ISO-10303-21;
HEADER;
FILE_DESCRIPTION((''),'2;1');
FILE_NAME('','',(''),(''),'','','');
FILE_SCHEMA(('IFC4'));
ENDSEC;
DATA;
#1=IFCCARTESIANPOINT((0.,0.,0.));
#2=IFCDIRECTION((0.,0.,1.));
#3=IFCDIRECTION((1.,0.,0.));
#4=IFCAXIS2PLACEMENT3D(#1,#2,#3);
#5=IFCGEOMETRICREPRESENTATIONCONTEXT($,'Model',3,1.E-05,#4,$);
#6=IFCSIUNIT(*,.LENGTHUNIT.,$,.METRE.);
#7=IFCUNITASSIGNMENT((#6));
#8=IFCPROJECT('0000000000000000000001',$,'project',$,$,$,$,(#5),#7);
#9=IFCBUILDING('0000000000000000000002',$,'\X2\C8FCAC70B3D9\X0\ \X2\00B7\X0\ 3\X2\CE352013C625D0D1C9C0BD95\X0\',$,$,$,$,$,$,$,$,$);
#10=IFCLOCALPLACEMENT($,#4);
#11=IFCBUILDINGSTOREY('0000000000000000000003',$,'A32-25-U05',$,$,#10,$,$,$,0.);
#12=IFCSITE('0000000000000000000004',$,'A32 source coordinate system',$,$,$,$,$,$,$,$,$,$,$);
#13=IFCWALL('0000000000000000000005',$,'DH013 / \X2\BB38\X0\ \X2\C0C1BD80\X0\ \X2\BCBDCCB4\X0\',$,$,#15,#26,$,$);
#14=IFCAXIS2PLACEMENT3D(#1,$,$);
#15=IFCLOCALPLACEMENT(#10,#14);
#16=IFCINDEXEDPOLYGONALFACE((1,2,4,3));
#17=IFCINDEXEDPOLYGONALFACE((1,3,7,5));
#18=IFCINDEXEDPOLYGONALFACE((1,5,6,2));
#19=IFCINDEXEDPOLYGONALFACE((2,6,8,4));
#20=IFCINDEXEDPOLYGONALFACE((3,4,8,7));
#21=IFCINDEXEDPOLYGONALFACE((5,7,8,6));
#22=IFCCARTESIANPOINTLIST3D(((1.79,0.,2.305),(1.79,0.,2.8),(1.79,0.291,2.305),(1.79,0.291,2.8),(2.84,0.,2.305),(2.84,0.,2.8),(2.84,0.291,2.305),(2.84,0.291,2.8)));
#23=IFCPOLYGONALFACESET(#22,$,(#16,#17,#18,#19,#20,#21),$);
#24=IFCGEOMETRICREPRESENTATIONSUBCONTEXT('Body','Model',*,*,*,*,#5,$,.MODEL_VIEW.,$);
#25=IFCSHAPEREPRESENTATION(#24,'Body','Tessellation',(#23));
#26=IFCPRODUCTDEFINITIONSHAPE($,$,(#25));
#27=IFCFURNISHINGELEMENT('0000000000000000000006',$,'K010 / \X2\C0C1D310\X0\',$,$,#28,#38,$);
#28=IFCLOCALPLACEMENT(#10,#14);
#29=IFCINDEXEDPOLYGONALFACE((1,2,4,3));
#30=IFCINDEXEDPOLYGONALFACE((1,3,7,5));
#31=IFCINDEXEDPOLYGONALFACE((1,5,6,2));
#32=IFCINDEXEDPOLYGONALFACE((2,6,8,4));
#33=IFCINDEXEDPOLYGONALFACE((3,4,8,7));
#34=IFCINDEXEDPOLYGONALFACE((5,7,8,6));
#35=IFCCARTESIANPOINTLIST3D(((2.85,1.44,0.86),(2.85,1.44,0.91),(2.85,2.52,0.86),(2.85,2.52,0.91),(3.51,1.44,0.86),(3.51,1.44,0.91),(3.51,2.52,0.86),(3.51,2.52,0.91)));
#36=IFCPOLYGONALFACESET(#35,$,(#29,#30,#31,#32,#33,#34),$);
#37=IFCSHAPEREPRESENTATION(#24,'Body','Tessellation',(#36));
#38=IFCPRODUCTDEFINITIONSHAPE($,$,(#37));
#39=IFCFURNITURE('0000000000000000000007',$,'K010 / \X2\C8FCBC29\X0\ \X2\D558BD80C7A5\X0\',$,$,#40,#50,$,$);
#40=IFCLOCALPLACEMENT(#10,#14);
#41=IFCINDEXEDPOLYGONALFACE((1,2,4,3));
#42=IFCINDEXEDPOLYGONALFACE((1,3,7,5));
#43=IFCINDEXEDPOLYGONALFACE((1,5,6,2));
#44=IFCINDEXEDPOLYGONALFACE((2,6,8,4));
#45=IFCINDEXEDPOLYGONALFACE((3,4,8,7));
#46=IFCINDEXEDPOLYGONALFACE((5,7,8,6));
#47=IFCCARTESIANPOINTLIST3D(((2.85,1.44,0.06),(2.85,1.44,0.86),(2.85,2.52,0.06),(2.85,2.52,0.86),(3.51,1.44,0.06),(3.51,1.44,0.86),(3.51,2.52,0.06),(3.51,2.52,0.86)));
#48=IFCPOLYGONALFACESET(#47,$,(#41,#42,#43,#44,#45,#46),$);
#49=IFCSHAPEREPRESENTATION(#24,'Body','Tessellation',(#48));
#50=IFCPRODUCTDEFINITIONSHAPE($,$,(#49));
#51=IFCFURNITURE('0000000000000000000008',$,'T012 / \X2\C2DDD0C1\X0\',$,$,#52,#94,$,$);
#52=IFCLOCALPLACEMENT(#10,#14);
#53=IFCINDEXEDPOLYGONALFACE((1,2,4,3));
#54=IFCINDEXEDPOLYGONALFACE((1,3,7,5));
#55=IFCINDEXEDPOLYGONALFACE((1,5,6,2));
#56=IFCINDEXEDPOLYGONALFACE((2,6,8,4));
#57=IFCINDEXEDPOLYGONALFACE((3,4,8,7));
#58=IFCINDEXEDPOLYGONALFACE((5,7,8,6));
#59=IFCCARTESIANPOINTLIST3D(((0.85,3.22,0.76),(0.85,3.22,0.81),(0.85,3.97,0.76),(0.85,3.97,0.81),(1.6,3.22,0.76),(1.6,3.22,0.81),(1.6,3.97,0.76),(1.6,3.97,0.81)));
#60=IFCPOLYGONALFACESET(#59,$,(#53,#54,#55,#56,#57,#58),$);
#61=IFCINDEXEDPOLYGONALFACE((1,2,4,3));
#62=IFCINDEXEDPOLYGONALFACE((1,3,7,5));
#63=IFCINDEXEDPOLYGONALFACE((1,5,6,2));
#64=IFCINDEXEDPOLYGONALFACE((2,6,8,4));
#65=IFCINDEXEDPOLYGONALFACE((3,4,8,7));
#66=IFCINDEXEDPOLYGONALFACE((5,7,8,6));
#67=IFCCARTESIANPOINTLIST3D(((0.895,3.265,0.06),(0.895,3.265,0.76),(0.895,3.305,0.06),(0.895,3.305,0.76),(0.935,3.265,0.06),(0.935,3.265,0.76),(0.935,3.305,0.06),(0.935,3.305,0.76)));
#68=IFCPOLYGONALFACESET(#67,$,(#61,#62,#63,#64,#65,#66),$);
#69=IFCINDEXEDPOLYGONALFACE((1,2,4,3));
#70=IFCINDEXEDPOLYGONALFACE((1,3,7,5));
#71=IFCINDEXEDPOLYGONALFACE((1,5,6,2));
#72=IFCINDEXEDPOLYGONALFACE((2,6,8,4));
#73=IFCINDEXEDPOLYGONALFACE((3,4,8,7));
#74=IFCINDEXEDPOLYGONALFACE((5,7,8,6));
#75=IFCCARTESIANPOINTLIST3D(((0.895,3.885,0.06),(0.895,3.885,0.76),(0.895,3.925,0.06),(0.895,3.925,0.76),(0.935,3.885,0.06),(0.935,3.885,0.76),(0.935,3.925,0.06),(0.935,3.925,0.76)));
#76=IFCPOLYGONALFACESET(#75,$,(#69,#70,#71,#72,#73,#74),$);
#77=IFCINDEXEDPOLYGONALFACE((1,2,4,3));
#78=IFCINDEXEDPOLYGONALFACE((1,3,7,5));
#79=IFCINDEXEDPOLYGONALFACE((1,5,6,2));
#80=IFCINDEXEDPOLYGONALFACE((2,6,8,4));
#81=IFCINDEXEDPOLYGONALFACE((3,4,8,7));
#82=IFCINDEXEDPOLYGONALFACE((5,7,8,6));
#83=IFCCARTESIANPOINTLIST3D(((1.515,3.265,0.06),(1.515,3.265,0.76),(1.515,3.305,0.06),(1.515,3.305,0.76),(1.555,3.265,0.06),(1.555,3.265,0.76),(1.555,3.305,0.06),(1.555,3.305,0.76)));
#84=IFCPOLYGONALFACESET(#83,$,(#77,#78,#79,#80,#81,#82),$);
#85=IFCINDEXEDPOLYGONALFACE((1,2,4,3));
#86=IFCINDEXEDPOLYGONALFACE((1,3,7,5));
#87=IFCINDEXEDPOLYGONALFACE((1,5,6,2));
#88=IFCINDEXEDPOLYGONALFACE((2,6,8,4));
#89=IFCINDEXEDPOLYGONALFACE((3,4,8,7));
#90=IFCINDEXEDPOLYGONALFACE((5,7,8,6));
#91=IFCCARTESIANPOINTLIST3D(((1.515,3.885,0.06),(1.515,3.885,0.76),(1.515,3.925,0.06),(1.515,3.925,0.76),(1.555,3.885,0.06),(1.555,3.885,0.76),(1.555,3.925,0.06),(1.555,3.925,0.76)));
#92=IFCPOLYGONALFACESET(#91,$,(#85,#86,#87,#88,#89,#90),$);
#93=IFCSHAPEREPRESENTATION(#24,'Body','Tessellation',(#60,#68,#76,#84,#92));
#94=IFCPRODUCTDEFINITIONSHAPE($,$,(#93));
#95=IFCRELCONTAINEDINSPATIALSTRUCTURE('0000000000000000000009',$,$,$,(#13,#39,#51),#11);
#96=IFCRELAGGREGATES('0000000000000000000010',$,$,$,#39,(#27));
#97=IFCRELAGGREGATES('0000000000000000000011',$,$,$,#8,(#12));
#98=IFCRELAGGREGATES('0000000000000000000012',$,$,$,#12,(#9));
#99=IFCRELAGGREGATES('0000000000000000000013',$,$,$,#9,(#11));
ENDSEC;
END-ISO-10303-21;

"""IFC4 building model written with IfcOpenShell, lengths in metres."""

from ifc_helpers import new_model, si_unit, frame, origin_with_axes, place, context, subcontext, project, spatial, polyline, outline, extrude, element, aggregate, save


model = new_model("IFC4")

# Units and contexts
model_context = context("Model", 3, precision=1e-05, world=origin_with_axes())
body_context = subcontext(model_context, "Body", "Model", "MODEL_VIEW")
ifc_project = project(units=[si_unit("LENGTHUNIT", "METRE")], contexts=[model_context])

# Site, building, storey
site = spatial("IfcSite", under=ifc_project, Name="A32 source coordinate system")
building = spatial("IfcBuilding", under=site, Name="주거동 · 3층–옥탑지붕")
storey_placement = place(None, origin_with_axes())
storey = spatial("IfcBuildingStorey", under=building, at=storey_placement, Name="A32-25-U05", Elevation=0.0)

# Wall
wall_1_placement = place(storey_placement, origin_with_axes())
element("IfcWall", 1, at=wall_1_placement, inside=storey, Name="DH013 / 문 상부 벽체", context=body_context, shape_type="SweptSolid", body=[
    extrude(outline(polyline([(2.84, 0.291), (2.84, 0.0), (1.79, 0.0), (1.79, 0.291), (2.84, 0.291)])), frame((0.0, 0.0, 2.305)), (0.0, 0.0, 1.0), 0.495),
])

# Furnishing element
furniture_1_placement = place(storey_placement, origin_with_axes())
furnishing_1_placement = place(furniture_1_placement, origin_with_axes())
furnishing_1 = element("IfcFurnishingElement", 2, at=furnishing_1_placement, Name="K010 / 상판", context=body_context, shape_type="SweptSolid", body=[
    extrude(outline(polyline([(2.85, 2.52), (3.51, 2.52), (3.51, 1.44), (2.85, 1.44), (2.85, 2.52)])), frame((0.0, 0.0, 0.86)), (0.0, 0.0, 1.0), 0.05),
])

# Furniture
furniture_1 = element("IfcFurniture", 3, at=furniture_1_placement, inside=storey, Name="K010 / 주방 하부장", context=body_context, shape_type="SweptSolid", body=[
    extrude(outline(polyline([(2.85, 1.44), (2.85, 2.52), (3.51, 2.52), (3.51, 1.44), (2.85, 1.44)])), frame((0.0, 0.0, 0.06)), (0.0, 0.0, 1.0), 0.8),
])
aggregate(furniture_1, [furnishing_1])
furniture_2_placement = place(storey_placement, origin_with_axes())
element("IfcFurniture", 4, at=furniture_2_placement, inside=storey, Name="T012 / 식탁", context=body_context, shape_type="SweptSolid", body=[
    extrude(outline(polyline([(1.6, 3.97), (1.6, 3.22), (0.85, 3.22), (0.85, 3.97), (1.6, 3.97)])), frame((0.0, 0.0, 0.76)), (0.0, 0.0, 1.0), 0.05),
    extrude(outline(polyline([(0.895, 3.265), (0.895, 3.305), (0.935, 3.305), (0.935, 3.265), (0.895, 3.265)])), frame((0.0, 0.0, 0.06)), (0.0, 0.0, 1.0), 0.7),
    extrude(outline(polyline([(0.895, 3.885), (0.895, 3.925), (0.935, 3.925), (0.935, 3.885), (0.895, 3.885)])), frame((0.0, 0.0, 0.06)), (0.0, 0.0, 1.0), 0.7),
    extrude(outline(polyline([(1.515, 3.265), (1.515, 3.305), (1.555, 3.305), (1.555, 3.265), (1.515, 3.265)])), frame((0.0, 0.0, 0.06)), (0.0, 0.0, 1.0), 0.7),
    extrude(outline(polyline([(1.515, 3.885), (1.515, 3.925), (1.555, 3.925), (1.555, 3.885), (1.515, 3.885)])), frame((0.0, 0.0, 0.06)), (0.0, 0.0, 1.0), 0.7),
])

save(model, "model.ifc")
